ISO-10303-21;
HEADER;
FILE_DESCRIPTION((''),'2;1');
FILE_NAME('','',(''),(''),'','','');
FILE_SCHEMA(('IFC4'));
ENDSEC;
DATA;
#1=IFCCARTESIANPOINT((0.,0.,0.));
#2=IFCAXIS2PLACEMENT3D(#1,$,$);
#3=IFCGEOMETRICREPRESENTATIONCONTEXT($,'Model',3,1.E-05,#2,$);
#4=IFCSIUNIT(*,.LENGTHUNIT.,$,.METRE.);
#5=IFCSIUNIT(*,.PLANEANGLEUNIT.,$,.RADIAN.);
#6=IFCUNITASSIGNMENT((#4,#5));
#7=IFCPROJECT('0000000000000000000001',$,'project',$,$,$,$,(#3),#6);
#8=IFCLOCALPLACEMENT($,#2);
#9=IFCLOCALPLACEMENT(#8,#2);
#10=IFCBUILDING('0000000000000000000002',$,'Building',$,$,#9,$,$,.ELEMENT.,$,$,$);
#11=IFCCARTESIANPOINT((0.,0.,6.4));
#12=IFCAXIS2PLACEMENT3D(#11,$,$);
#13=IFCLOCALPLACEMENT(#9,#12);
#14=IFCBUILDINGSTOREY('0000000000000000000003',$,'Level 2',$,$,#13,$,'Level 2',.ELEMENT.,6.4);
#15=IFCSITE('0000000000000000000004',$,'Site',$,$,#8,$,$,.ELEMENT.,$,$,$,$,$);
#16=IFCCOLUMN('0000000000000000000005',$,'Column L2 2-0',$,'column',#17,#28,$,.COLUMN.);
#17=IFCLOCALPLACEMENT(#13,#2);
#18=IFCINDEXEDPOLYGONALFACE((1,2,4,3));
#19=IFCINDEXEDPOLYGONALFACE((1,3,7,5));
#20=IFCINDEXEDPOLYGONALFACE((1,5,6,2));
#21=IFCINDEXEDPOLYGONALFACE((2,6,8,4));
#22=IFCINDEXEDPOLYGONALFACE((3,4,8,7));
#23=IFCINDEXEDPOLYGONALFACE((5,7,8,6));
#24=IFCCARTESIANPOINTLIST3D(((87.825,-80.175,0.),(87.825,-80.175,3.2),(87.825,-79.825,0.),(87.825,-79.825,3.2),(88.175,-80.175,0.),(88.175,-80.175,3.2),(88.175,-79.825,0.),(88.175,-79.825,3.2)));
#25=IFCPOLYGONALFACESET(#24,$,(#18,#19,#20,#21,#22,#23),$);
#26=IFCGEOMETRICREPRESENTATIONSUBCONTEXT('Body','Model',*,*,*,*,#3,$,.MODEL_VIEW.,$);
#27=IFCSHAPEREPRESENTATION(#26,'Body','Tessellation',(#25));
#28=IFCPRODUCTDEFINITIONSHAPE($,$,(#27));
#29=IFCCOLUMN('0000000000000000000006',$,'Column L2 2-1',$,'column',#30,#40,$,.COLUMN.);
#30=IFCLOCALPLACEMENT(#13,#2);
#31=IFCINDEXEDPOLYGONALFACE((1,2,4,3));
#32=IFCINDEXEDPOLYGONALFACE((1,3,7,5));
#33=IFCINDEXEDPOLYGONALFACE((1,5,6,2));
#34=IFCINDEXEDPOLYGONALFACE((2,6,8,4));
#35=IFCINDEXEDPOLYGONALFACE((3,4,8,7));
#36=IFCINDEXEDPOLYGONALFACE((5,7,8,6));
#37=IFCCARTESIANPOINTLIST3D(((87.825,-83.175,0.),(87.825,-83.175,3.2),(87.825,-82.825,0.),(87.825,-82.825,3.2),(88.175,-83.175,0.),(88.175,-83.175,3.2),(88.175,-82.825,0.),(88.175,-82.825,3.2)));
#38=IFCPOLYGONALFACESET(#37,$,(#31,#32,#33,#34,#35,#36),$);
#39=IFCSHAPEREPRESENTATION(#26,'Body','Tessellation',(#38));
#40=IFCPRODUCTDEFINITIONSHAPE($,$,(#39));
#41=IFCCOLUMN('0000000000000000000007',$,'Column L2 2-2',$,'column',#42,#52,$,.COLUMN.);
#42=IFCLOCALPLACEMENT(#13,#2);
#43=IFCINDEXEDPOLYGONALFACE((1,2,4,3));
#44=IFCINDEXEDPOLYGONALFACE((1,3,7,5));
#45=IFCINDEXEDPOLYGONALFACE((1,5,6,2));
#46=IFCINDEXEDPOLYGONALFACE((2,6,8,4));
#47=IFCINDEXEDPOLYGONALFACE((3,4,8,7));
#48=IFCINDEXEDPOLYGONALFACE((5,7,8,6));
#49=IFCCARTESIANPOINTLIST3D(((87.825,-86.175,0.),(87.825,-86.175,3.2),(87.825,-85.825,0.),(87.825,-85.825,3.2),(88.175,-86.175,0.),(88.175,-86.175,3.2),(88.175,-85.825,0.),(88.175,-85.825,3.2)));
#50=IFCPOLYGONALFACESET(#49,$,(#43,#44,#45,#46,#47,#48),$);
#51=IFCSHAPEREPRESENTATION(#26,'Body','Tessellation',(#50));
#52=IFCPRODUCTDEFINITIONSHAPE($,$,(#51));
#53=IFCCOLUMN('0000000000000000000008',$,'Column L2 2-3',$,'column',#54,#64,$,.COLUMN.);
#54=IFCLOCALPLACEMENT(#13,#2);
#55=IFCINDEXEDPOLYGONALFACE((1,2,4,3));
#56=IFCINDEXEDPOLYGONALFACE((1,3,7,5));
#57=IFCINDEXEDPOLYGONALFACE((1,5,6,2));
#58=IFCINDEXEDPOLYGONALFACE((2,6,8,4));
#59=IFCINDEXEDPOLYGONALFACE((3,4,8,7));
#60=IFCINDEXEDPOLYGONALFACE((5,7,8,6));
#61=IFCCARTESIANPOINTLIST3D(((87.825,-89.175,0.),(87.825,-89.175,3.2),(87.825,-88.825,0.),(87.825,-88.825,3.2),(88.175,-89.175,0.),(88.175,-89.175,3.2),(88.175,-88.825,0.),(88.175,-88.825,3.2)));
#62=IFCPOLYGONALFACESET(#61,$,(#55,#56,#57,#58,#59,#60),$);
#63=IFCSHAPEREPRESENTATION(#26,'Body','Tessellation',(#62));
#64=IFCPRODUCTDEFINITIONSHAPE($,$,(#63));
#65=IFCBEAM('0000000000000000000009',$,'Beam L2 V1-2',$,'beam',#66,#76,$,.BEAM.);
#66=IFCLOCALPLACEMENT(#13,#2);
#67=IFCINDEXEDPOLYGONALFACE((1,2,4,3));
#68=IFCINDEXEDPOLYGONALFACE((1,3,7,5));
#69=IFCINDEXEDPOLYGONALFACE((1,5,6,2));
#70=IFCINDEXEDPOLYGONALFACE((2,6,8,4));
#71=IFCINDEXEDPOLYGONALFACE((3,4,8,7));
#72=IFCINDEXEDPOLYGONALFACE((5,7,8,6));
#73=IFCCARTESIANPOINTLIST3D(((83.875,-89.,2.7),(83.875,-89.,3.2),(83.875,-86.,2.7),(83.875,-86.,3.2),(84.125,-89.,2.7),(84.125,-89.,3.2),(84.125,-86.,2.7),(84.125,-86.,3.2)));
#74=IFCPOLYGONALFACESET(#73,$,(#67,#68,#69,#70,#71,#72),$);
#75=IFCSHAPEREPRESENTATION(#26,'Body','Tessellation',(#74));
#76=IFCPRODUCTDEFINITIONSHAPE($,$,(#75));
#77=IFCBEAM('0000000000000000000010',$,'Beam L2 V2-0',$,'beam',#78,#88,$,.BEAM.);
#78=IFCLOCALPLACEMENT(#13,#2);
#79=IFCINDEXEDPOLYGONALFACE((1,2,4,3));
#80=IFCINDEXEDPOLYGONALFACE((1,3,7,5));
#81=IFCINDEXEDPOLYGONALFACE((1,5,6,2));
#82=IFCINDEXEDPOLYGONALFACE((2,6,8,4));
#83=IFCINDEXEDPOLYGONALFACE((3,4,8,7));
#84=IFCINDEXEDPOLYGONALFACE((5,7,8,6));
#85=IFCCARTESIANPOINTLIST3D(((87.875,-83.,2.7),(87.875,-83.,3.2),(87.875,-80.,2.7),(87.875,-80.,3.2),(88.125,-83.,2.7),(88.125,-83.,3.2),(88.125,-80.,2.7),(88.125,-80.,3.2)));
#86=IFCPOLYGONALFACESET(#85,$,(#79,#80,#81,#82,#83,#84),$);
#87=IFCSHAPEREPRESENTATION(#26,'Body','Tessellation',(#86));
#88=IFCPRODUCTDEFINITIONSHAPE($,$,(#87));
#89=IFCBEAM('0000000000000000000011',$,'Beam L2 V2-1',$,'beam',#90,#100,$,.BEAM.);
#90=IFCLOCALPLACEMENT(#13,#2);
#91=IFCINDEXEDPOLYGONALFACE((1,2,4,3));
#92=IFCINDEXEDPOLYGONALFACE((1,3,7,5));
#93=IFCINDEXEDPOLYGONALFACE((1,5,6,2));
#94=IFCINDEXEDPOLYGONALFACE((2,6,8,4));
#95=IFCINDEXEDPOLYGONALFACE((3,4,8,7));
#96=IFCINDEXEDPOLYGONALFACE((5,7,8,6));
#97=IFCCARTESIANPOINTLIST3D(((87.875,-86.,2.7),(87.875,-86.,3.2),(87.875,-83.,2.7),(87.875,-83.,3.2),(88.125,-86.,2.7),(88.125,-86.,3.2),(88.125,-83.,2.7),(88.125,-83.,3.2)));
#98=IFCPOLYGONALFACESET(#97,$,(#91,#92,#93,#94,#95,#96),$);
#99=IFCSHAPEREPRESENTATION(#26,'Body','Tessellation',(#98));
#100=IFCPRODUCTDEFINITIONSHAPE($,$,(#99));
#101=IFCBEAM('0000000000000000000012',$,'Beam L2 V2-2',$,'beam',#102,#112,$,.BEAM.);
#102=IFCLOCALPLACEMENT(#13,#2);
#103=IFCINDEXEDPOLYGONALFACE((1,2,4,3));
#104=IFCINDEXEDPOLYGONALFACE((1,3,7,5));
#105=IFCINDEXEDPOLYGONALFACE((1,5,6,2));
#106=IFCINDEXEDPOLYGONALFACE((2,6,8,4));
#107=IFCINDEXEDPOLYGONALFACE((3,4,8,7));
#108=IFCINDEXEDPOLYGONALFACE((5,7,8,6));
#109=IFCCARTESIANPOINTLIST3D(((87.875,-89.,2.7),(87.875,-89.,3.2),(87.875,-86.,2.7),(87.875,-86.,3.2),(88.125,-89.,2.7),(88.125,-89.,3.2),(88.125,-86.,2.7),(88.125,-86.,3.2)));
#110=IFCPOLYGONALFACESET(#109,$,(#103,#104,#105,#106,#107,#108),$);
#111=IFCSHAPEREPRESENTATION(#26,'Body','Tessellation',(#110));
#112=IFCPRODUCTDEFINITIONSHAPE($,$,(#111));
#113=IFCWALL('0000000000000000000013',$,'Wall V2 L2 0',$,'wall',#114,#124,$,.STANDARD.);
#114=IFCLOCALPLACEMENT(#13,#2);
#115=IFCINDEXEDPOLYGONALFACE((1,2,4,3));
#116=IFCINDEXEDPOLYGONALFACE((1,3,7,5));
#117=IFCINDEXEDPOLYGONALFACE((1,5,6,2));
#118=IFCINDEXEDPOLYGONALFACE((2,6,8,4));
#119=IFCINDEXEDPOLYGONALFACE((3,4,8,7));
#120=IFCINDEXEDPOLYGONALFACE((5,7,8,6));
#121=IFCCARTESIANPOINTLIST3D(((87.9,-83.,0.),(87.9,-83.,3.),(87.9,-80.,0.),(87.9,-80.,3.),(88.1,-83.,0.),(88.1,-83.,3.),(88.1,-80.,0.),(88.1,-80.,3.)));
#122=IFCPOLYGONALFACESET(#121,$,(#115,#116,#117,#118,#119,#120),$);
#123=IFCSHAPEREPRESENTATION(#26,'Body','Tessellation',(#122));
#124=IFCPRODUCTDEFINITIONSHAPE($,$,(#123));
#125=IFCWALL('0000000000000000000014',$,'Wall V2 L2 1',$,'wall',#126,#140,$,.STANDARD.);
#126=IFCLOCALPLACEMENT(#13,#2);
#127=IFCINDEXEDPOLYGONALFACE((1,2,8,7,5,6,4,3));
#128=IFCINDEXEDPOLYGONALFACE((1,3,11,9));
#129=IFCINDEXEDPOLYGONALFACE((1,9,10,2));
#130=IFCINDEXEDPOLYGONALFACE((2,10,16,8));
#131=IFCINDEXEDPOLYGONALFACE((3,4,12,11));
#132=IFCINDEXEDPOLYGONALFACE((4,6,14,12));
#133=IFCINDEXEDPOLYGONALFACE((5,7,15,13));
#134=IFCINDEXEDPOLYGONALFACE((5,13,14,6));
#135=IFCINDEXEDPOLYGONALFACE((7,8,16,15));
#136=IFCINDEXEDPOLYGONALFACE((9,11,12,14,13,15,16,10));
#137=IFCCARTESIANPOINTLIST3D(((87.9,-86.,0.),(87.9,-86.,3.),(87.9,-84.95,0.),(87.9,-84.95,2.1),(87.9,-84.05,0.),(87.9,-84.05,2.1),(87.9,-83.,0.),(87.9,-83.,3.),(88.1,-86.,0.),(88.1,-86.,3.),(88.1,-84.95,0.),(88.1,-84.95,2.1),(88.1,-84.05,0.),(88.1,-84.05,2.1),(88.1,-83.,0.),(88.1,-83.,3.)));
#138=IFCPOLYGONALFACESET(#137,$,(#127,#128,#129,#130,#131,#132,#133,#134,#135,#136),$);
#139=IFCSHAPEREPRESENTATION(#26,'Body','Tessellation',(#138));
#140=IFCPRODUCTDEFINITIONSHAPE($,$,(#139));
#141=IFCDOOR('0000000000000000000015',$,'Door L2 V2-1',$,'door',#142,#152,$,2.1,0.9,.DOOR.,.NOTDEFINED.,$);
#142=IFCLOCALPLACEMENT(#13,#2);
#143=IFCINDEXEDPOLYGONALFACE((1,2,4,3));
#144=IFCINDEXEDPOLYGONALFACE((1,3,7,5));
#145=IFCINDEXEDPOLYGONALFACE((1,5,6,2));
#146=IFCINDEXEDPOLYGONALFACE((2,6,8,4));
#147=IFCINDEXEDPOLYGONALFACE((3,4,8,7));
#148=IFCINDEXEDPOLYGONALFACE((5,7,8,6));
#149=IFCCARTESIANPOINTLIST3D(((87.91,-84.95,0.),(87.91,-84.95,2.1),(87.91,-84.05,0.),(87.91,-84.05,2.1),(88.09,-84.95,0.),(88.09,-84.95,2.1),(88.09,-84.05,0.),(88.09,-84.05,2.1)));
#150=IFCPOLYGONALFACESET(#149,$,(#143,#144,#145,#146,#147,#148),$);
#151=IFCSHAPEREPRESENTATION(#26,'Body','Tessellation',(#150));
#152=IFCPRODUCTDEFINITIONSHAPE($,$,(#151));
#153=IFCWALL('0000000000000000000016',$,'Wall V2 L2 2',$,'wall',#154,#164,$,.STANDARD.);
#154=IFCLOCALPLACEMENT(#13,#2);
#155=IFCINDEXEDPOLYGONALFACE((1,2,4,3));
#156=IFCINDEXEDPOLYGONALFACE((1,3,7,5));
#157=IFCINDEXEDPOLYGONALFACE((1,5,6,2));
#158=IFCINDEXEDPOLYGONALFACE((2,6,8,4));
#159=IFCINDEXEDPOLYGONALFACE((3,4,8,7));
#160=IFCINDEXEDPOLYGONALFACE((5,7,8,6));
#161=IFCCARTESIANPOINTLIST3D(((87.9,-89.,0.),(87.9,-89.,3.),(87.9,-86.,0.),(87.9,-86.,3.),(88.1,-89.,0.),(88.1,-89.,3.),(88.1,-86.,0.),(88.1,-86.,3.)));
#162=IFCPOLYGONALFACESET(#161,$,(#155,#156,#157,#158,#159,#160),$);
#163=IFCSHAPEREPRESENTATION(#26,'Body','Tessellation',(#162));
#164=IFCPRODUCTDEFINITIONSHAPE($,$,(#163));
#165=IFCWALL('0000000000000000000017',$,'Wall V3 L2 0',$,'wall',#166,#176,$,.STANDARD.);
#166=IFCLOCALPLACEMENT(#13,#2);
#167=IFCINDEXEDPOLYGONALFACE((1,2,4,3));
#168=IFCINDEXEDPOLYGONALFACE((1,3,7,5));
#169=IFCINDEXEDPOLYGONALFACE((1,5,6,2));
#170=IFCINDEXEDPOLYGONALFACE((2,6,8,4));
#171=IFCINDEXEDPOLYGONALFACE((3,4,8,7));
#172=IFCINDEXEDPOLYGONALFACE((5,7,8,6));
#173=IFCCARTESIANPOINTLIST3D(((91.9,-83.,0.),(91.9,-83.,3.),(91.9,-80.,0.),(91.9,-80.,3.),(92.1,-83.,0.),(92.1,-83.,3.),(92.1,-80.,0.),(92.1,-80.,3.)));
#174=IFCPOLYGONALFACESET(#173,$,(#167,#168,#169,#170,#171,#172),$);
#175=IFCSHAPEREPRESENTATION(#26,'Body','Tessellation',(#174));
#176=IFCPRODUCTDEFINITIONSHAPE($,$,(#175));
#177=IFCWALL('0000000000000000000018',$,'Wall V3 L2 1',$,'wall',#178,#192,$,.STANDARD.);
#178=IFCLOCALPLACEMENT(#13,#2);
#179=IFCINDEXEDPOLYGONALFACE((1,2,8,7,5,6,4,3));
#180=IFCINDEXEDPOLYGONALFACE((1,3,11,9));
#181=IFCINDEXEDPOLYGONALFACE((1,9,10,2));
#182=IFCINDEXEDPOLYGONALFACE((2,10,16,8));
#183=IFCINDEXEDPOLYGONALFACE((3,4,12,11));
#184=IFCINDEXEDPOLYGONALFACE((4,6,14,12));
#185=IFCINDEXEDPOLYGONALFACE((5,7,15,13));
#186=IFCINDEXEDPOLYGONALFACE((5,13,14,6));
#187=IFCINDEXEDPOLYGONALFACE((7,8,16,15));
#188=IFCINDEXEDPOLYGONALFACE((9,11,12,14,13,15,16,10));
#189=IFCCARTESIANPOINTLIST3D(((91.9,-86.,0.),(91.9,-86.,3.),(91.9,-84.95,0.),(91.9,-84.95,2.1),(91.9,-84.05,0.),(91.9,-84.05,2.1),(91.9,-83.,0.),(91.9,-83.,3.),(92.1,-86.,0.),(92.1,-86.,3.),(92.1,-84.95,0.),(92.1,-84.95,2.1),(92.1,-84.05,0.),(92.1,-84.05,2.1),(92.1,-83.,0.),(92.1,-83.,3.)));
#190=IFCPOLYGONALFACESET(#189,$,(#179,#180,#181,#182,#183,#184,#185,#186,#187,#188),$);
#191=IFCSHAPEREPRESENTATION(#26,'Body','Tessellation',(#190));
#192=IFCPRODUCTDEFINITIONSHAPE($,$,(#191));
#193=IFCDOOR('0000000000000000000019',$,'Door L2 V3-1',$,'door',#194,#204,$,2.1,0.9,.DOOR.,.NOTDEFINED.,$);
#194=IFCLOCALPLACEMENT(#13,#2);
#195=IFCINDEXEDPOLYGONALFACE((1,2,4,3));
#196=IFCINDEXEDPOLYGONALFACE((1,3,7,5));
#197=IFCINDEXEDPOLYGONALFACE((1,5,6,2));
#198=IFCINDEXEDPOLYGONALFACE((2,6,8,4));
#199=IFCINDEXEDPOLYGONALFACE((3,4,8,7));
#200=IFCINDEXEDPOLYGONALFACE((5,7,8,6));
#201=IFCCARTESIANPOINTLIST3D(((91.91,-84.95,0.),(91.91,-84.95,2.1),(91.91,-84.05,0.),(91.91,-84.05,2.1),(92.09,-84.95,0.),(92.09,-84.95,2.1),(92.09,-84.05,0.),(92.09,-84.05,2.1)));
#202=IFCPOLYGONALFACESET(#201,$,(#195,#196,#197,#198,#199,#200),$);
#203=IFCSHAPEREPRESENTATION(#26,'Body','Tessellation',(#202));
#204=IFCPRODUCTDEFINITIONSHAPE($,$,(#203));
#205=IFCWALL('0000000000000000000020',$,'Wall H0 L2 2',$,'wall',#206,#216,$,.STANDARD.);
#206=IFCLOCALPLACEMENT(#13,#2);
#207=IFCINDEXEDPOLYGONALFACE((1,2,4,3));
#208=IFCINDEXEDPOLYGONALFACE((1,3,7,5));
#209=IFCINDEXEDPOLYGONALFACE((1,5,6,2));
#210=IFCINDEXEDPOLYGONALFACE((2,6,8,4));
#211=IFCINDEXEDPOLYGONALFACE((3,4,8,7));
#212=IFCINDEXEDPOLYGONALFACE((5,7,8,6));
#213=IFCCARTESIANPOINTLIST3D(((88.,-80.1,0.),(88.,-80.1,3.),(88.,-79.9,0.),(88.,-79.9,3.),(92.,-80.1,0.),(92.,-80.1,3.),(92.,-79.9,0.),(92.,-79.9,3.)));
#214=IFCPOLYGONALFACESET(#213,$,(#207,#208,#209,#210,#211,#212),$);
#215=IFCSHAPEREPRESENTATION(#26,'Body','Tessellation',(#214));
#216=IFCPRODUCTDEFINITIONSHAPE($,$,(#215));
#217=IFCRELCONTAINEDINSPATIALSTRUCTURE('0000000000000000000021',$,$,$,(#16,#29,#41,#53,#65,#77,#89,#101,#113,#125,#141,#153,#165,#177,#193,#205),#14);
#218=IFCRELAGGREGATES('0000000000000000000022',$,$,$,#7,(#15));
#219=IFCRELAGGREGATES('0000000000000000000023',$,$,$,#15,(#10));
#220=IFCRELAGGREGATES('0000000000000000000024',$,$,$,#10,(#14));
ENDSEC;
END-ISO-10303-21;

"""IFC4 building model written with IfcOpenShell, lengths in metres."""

from ifc_helpers import new_model, si_unit, frame, frame_2d, origin, origin_2d, place, context, subcontext, project, spatial, rectangle, extrude, element, fill, save


model = new_model("IFC4")

# Units and contexts
model_context = context("Model", 3, precision=1e-05, world=origin())
body_context = subcontext(model_context, "Body", "Model", "MODEL_VIEW")
ifc_project = project(units=[si_unit("LENGTHUNIT", "METRE"), si_unit("PLANEANGLEUNIT", "RADIAN")], contexts=[model_context])

# Site, building, storey
site_placement = place(None, origin())
site = spatial("IfcSite", under=ifc_project, at=site_placement, Name="Site", CompositionType="ELEMENT")
building_placement = place(site_placement, origin())
building = spatial("IfcBuilding", under=site, at=building_placement, Name="Building", CompositionType="ELEMENT")
storey_placement = place(building_placement, frame((0.0, 0.0, 6.4)))
storey = spatial("IfcBuildingStorey", under=building, at=storey_placement, Name="Level 2", LongName="Level 2", CompositionType="ELEMENT", Elevation=6.4)

# Columns
for number, where, name in (
    (1, (88.0, -80.0, 0.0), "Column L2 2-0"),
    (2, (88.0, -83.0, 0.0), "Column L2 2-1"),
    (3, (88.0, -86.0, 0.0), "Column L2 2-2"),
    (4, (88.0, -89.0, 0.0), "Column L2 2-3"),
):
    element("IfcColumn", number, at=place(storey_placement, frame(where)), inside=storey, Name=name, ObjectType="column", PredefinedType="COLUMN", context=body_context, shape_type="SweptSolid", body=[
        extrude(rectangle(XDim=0.35, YDim=0.35, at=origin_2d()), origin(), (0.0, 0.0, 1.0), 3.2),
    ])

# Beams
for number, where, z_axis, x_axis, name in (
    (5, (84.0, -86.0, 2.95), (0.0, -1.0, 0.0), (0.0, 0.0, 1.0), "Beam L2 V1-2"),
    (6, (88.0, -80.0, 2.95), (0.0, -1.0, 0.0), (0.0, 0.0, 1.0), "Beam L2 V2-0"),
    (7, (88.0, -83.0, 2.95), (0.0, -1.0, 0.0), (0.0, 0.0, 1.0), "Beam L2 V2-1"),
    (8, (88.0, -86.0, 2.95), (0.0, -1.0, 0.0), (0.0, 0.0, 1.0), "Beam L2 V2-2"),
):
    element("IfcBeam", number, at=place(storey_placement, frame(where, z_axis=z_axis, x_axis=x_axis)), inside=storey, Name=name, ObjectType="beam", PredefinedType="BEAM", context=body_context, shape_type="SweptSolid", body=[
        extrude(rectangle(XDim=0.5, YDim=0.25, at=origin_2d()), origin(), (0.0, 0.0, 1.0), 3.0),
    ])

# Wall
wall_1_placement = place(storey_placement, frame((88.0, -80.0, 0.0), z_axis=(0.0, 0.0, 1.0), x_axis=(0.0, -1.0, 0.0)))
element("IfcWall", 9, at=wall_1_placement, inside=storey, Name="Wall V2 L2 0", ObjectType="wall", PredefinedType="STANDARD", context=body_context, shape_type="SweptSolid", body=[
    extrude(rectangle(XDim=3.0, YDim=0.2, at=frame_2d((1.5, 0.0))), origin(), (0.0, 0.0, 1.0), 3.0),
])

# Wall, opening, door
wall_2_placement = place(storey_placement, frame((88.0, -83.0, 0.0), z_axis=(0.0, 0.0, 1.0), x_axis=(0.0, -1.0, 0.0)))
wall_2 = element("IfcWall", 10, at=wall_2_placement, inside=storey, Name="Wall V2 L2 1", ObjectType="wall", PredefinedType="STANDARD", context=body_context, shape_type="SweptSolid", body=[
    extrude(rectangle(XDim=3.0, YDim=0.2, at=frame_2d((1.5, 0.0))), origin(), (0.0, 0.0, 1.0), 3.0),
])
opening_1_placement = place(storey_placement, frame((88.0, -84.5, 0.0), z_axis=(0.0, 0.0, 1.0), x_axis=(0.0, -1.0, 0.0)))
opening_1 = element("IfcOpeningElement", 11, at=opening_1_placement, cuts=wall_2, ObjectType="Opening", PredefinedType="OPENING", context=body_context, shape_type="SweptSolid", body=[
    extrude(rectangle(XDim=0.9, YDim=0.22, at=origin_2d()), origin(), (0.0, 0.0, 1.0), 2.1),
])
door_1_placement = place(storey_placement, frame((88.0, -84.5, 0.0), z_axis=(0.0, 0.0, 1.0), x_axis=(0.0, -1.0, 0.0)))
door_1 = element("IfcDoor", 12, at=door_1_placement, inside=storey, Name="Door L2 V2-1", ObjectType="door", OperationType="NOTDEFINED", OverallHeight=2.1, OverallWidth=0.9, PredefinedType="DOOR", context=body_context, shape_type="SweptSolid", body=[
    extrude(rectangle(XDim=0.9, YDim=0.18, at=origin_2d()), origin(), (0.0, 0.0, 1.0), 2.1),
])
fill(opening_1, door_1)

# Walls
for number, where, z_axis, x_axis, name in (
    (13, (88.0, -86.0, 0.0), (0.0, 0.0, 1.0), (0.0, -1.0, 0.0), "Wall V2 L2 2"),
    (14, (92.0, -80.0, 0.0), (0.0, 0.0, 1.0), (0.0, -1.0, 0.0), "Wall V3 L2 0"),
):
    element("IfcWall", number, at=place(storey_placement, frame(where, z_axis=z_axis, x_axis=x_axis)), inside=storey, Name=name, ObjectType="wall", PredefinedType="STANDARD", context=body_context, shape_type="SweptSolid", body=[
        extrude(rectangle(XDim=3.0, YDim=0.2, at=frame_2d((1.5, 0.0))), origin(), (0.0, 0.0, 1.0), 3.0),
    ])

# Wall, opening, door
wall_3_placement = place(storey_placement, frame((92.0, -83.0, 0.0), z_axis=(0.0, 0.0, 1.0), x_axis=(0.0, -1.0, 0.0)))
wall_3 = element("IfcWall", 15, at=wall_3_placement, inside=storey, Name="Wall V3 L2 1", ObjectType="wall", PredefinedType="STANDARD", context=body_context, shape_type="SweptSolid", body=[
    extrude(rectangle(XDim=3.0, YDim=0.2, at=frame_2d((1.5, 0.0))), origin(), (0.0, 0.0, 1.0), 3.0),
])
opening_2_placement = place(storey_placement, frame((92.0, -84.5, 0.0), z_axis=(0.0, 0.0, 1.0), x_axis=(0.0, -1.0, 0.0)))
opening_2 = element("IfcOpeningElement", 16, at=opening_2_placement, cuts=wall_3, ObjectType="Opening", PredefinedType="OPENING", context=body_context, shape_type="SweptSolid", body=[
    extrude(rectangle(XDim=0.9, YDim=0.22, at=origin_2d()), origin(), (0.0, 0.0, 1.0), 2.1),
])
door_2_placement = place(storey_placement, frame((92.0, -84.5, 0.0), z_axis=(0.0, 0.0, 1.0), x_axis=(0.0, -1.0, 0.0)))
door_2 = element("IfcDoor", 17, at=door_2_placement, inside=storey, Name="Door L2 V3-1", ObjectType="door", OperationType="NOTDEFINED", OverallHeight=2.1, OverallWidth=0.9, PredefinedType="DOOR", context=body_context, shape_type="SweptSolid", body=[
    extrude(rectangle(XDim=0.9, YDim=0.18, at=origin_2d()), origin(), (0.0, 0.0, 1.0), 2.1),
])
fill(opening_2, door_2)

# Wall
wall_4_placement = place(storey_placement, frame((88.0, -80.0, 0.0), z_axis=(0.0, 0.0, 1.0), x_axis=(1.0, 0.0, 0.0)))
element("IfcWall", 18, at=wall_4_placement, inside=storey, Name="Wall H0 L2 2", ObjectType="wall", PredefinedType="STANDARD", context=body_context, shape_type="SweptSolid", body=[
    extrude(rectangle(XDim=4.0, YDim=0.2, at=frame_2d((2.0, 0.0))), origin(), (0.0, 0.0, 1.0), 3.0),
])

save(model, "model.ifc")
